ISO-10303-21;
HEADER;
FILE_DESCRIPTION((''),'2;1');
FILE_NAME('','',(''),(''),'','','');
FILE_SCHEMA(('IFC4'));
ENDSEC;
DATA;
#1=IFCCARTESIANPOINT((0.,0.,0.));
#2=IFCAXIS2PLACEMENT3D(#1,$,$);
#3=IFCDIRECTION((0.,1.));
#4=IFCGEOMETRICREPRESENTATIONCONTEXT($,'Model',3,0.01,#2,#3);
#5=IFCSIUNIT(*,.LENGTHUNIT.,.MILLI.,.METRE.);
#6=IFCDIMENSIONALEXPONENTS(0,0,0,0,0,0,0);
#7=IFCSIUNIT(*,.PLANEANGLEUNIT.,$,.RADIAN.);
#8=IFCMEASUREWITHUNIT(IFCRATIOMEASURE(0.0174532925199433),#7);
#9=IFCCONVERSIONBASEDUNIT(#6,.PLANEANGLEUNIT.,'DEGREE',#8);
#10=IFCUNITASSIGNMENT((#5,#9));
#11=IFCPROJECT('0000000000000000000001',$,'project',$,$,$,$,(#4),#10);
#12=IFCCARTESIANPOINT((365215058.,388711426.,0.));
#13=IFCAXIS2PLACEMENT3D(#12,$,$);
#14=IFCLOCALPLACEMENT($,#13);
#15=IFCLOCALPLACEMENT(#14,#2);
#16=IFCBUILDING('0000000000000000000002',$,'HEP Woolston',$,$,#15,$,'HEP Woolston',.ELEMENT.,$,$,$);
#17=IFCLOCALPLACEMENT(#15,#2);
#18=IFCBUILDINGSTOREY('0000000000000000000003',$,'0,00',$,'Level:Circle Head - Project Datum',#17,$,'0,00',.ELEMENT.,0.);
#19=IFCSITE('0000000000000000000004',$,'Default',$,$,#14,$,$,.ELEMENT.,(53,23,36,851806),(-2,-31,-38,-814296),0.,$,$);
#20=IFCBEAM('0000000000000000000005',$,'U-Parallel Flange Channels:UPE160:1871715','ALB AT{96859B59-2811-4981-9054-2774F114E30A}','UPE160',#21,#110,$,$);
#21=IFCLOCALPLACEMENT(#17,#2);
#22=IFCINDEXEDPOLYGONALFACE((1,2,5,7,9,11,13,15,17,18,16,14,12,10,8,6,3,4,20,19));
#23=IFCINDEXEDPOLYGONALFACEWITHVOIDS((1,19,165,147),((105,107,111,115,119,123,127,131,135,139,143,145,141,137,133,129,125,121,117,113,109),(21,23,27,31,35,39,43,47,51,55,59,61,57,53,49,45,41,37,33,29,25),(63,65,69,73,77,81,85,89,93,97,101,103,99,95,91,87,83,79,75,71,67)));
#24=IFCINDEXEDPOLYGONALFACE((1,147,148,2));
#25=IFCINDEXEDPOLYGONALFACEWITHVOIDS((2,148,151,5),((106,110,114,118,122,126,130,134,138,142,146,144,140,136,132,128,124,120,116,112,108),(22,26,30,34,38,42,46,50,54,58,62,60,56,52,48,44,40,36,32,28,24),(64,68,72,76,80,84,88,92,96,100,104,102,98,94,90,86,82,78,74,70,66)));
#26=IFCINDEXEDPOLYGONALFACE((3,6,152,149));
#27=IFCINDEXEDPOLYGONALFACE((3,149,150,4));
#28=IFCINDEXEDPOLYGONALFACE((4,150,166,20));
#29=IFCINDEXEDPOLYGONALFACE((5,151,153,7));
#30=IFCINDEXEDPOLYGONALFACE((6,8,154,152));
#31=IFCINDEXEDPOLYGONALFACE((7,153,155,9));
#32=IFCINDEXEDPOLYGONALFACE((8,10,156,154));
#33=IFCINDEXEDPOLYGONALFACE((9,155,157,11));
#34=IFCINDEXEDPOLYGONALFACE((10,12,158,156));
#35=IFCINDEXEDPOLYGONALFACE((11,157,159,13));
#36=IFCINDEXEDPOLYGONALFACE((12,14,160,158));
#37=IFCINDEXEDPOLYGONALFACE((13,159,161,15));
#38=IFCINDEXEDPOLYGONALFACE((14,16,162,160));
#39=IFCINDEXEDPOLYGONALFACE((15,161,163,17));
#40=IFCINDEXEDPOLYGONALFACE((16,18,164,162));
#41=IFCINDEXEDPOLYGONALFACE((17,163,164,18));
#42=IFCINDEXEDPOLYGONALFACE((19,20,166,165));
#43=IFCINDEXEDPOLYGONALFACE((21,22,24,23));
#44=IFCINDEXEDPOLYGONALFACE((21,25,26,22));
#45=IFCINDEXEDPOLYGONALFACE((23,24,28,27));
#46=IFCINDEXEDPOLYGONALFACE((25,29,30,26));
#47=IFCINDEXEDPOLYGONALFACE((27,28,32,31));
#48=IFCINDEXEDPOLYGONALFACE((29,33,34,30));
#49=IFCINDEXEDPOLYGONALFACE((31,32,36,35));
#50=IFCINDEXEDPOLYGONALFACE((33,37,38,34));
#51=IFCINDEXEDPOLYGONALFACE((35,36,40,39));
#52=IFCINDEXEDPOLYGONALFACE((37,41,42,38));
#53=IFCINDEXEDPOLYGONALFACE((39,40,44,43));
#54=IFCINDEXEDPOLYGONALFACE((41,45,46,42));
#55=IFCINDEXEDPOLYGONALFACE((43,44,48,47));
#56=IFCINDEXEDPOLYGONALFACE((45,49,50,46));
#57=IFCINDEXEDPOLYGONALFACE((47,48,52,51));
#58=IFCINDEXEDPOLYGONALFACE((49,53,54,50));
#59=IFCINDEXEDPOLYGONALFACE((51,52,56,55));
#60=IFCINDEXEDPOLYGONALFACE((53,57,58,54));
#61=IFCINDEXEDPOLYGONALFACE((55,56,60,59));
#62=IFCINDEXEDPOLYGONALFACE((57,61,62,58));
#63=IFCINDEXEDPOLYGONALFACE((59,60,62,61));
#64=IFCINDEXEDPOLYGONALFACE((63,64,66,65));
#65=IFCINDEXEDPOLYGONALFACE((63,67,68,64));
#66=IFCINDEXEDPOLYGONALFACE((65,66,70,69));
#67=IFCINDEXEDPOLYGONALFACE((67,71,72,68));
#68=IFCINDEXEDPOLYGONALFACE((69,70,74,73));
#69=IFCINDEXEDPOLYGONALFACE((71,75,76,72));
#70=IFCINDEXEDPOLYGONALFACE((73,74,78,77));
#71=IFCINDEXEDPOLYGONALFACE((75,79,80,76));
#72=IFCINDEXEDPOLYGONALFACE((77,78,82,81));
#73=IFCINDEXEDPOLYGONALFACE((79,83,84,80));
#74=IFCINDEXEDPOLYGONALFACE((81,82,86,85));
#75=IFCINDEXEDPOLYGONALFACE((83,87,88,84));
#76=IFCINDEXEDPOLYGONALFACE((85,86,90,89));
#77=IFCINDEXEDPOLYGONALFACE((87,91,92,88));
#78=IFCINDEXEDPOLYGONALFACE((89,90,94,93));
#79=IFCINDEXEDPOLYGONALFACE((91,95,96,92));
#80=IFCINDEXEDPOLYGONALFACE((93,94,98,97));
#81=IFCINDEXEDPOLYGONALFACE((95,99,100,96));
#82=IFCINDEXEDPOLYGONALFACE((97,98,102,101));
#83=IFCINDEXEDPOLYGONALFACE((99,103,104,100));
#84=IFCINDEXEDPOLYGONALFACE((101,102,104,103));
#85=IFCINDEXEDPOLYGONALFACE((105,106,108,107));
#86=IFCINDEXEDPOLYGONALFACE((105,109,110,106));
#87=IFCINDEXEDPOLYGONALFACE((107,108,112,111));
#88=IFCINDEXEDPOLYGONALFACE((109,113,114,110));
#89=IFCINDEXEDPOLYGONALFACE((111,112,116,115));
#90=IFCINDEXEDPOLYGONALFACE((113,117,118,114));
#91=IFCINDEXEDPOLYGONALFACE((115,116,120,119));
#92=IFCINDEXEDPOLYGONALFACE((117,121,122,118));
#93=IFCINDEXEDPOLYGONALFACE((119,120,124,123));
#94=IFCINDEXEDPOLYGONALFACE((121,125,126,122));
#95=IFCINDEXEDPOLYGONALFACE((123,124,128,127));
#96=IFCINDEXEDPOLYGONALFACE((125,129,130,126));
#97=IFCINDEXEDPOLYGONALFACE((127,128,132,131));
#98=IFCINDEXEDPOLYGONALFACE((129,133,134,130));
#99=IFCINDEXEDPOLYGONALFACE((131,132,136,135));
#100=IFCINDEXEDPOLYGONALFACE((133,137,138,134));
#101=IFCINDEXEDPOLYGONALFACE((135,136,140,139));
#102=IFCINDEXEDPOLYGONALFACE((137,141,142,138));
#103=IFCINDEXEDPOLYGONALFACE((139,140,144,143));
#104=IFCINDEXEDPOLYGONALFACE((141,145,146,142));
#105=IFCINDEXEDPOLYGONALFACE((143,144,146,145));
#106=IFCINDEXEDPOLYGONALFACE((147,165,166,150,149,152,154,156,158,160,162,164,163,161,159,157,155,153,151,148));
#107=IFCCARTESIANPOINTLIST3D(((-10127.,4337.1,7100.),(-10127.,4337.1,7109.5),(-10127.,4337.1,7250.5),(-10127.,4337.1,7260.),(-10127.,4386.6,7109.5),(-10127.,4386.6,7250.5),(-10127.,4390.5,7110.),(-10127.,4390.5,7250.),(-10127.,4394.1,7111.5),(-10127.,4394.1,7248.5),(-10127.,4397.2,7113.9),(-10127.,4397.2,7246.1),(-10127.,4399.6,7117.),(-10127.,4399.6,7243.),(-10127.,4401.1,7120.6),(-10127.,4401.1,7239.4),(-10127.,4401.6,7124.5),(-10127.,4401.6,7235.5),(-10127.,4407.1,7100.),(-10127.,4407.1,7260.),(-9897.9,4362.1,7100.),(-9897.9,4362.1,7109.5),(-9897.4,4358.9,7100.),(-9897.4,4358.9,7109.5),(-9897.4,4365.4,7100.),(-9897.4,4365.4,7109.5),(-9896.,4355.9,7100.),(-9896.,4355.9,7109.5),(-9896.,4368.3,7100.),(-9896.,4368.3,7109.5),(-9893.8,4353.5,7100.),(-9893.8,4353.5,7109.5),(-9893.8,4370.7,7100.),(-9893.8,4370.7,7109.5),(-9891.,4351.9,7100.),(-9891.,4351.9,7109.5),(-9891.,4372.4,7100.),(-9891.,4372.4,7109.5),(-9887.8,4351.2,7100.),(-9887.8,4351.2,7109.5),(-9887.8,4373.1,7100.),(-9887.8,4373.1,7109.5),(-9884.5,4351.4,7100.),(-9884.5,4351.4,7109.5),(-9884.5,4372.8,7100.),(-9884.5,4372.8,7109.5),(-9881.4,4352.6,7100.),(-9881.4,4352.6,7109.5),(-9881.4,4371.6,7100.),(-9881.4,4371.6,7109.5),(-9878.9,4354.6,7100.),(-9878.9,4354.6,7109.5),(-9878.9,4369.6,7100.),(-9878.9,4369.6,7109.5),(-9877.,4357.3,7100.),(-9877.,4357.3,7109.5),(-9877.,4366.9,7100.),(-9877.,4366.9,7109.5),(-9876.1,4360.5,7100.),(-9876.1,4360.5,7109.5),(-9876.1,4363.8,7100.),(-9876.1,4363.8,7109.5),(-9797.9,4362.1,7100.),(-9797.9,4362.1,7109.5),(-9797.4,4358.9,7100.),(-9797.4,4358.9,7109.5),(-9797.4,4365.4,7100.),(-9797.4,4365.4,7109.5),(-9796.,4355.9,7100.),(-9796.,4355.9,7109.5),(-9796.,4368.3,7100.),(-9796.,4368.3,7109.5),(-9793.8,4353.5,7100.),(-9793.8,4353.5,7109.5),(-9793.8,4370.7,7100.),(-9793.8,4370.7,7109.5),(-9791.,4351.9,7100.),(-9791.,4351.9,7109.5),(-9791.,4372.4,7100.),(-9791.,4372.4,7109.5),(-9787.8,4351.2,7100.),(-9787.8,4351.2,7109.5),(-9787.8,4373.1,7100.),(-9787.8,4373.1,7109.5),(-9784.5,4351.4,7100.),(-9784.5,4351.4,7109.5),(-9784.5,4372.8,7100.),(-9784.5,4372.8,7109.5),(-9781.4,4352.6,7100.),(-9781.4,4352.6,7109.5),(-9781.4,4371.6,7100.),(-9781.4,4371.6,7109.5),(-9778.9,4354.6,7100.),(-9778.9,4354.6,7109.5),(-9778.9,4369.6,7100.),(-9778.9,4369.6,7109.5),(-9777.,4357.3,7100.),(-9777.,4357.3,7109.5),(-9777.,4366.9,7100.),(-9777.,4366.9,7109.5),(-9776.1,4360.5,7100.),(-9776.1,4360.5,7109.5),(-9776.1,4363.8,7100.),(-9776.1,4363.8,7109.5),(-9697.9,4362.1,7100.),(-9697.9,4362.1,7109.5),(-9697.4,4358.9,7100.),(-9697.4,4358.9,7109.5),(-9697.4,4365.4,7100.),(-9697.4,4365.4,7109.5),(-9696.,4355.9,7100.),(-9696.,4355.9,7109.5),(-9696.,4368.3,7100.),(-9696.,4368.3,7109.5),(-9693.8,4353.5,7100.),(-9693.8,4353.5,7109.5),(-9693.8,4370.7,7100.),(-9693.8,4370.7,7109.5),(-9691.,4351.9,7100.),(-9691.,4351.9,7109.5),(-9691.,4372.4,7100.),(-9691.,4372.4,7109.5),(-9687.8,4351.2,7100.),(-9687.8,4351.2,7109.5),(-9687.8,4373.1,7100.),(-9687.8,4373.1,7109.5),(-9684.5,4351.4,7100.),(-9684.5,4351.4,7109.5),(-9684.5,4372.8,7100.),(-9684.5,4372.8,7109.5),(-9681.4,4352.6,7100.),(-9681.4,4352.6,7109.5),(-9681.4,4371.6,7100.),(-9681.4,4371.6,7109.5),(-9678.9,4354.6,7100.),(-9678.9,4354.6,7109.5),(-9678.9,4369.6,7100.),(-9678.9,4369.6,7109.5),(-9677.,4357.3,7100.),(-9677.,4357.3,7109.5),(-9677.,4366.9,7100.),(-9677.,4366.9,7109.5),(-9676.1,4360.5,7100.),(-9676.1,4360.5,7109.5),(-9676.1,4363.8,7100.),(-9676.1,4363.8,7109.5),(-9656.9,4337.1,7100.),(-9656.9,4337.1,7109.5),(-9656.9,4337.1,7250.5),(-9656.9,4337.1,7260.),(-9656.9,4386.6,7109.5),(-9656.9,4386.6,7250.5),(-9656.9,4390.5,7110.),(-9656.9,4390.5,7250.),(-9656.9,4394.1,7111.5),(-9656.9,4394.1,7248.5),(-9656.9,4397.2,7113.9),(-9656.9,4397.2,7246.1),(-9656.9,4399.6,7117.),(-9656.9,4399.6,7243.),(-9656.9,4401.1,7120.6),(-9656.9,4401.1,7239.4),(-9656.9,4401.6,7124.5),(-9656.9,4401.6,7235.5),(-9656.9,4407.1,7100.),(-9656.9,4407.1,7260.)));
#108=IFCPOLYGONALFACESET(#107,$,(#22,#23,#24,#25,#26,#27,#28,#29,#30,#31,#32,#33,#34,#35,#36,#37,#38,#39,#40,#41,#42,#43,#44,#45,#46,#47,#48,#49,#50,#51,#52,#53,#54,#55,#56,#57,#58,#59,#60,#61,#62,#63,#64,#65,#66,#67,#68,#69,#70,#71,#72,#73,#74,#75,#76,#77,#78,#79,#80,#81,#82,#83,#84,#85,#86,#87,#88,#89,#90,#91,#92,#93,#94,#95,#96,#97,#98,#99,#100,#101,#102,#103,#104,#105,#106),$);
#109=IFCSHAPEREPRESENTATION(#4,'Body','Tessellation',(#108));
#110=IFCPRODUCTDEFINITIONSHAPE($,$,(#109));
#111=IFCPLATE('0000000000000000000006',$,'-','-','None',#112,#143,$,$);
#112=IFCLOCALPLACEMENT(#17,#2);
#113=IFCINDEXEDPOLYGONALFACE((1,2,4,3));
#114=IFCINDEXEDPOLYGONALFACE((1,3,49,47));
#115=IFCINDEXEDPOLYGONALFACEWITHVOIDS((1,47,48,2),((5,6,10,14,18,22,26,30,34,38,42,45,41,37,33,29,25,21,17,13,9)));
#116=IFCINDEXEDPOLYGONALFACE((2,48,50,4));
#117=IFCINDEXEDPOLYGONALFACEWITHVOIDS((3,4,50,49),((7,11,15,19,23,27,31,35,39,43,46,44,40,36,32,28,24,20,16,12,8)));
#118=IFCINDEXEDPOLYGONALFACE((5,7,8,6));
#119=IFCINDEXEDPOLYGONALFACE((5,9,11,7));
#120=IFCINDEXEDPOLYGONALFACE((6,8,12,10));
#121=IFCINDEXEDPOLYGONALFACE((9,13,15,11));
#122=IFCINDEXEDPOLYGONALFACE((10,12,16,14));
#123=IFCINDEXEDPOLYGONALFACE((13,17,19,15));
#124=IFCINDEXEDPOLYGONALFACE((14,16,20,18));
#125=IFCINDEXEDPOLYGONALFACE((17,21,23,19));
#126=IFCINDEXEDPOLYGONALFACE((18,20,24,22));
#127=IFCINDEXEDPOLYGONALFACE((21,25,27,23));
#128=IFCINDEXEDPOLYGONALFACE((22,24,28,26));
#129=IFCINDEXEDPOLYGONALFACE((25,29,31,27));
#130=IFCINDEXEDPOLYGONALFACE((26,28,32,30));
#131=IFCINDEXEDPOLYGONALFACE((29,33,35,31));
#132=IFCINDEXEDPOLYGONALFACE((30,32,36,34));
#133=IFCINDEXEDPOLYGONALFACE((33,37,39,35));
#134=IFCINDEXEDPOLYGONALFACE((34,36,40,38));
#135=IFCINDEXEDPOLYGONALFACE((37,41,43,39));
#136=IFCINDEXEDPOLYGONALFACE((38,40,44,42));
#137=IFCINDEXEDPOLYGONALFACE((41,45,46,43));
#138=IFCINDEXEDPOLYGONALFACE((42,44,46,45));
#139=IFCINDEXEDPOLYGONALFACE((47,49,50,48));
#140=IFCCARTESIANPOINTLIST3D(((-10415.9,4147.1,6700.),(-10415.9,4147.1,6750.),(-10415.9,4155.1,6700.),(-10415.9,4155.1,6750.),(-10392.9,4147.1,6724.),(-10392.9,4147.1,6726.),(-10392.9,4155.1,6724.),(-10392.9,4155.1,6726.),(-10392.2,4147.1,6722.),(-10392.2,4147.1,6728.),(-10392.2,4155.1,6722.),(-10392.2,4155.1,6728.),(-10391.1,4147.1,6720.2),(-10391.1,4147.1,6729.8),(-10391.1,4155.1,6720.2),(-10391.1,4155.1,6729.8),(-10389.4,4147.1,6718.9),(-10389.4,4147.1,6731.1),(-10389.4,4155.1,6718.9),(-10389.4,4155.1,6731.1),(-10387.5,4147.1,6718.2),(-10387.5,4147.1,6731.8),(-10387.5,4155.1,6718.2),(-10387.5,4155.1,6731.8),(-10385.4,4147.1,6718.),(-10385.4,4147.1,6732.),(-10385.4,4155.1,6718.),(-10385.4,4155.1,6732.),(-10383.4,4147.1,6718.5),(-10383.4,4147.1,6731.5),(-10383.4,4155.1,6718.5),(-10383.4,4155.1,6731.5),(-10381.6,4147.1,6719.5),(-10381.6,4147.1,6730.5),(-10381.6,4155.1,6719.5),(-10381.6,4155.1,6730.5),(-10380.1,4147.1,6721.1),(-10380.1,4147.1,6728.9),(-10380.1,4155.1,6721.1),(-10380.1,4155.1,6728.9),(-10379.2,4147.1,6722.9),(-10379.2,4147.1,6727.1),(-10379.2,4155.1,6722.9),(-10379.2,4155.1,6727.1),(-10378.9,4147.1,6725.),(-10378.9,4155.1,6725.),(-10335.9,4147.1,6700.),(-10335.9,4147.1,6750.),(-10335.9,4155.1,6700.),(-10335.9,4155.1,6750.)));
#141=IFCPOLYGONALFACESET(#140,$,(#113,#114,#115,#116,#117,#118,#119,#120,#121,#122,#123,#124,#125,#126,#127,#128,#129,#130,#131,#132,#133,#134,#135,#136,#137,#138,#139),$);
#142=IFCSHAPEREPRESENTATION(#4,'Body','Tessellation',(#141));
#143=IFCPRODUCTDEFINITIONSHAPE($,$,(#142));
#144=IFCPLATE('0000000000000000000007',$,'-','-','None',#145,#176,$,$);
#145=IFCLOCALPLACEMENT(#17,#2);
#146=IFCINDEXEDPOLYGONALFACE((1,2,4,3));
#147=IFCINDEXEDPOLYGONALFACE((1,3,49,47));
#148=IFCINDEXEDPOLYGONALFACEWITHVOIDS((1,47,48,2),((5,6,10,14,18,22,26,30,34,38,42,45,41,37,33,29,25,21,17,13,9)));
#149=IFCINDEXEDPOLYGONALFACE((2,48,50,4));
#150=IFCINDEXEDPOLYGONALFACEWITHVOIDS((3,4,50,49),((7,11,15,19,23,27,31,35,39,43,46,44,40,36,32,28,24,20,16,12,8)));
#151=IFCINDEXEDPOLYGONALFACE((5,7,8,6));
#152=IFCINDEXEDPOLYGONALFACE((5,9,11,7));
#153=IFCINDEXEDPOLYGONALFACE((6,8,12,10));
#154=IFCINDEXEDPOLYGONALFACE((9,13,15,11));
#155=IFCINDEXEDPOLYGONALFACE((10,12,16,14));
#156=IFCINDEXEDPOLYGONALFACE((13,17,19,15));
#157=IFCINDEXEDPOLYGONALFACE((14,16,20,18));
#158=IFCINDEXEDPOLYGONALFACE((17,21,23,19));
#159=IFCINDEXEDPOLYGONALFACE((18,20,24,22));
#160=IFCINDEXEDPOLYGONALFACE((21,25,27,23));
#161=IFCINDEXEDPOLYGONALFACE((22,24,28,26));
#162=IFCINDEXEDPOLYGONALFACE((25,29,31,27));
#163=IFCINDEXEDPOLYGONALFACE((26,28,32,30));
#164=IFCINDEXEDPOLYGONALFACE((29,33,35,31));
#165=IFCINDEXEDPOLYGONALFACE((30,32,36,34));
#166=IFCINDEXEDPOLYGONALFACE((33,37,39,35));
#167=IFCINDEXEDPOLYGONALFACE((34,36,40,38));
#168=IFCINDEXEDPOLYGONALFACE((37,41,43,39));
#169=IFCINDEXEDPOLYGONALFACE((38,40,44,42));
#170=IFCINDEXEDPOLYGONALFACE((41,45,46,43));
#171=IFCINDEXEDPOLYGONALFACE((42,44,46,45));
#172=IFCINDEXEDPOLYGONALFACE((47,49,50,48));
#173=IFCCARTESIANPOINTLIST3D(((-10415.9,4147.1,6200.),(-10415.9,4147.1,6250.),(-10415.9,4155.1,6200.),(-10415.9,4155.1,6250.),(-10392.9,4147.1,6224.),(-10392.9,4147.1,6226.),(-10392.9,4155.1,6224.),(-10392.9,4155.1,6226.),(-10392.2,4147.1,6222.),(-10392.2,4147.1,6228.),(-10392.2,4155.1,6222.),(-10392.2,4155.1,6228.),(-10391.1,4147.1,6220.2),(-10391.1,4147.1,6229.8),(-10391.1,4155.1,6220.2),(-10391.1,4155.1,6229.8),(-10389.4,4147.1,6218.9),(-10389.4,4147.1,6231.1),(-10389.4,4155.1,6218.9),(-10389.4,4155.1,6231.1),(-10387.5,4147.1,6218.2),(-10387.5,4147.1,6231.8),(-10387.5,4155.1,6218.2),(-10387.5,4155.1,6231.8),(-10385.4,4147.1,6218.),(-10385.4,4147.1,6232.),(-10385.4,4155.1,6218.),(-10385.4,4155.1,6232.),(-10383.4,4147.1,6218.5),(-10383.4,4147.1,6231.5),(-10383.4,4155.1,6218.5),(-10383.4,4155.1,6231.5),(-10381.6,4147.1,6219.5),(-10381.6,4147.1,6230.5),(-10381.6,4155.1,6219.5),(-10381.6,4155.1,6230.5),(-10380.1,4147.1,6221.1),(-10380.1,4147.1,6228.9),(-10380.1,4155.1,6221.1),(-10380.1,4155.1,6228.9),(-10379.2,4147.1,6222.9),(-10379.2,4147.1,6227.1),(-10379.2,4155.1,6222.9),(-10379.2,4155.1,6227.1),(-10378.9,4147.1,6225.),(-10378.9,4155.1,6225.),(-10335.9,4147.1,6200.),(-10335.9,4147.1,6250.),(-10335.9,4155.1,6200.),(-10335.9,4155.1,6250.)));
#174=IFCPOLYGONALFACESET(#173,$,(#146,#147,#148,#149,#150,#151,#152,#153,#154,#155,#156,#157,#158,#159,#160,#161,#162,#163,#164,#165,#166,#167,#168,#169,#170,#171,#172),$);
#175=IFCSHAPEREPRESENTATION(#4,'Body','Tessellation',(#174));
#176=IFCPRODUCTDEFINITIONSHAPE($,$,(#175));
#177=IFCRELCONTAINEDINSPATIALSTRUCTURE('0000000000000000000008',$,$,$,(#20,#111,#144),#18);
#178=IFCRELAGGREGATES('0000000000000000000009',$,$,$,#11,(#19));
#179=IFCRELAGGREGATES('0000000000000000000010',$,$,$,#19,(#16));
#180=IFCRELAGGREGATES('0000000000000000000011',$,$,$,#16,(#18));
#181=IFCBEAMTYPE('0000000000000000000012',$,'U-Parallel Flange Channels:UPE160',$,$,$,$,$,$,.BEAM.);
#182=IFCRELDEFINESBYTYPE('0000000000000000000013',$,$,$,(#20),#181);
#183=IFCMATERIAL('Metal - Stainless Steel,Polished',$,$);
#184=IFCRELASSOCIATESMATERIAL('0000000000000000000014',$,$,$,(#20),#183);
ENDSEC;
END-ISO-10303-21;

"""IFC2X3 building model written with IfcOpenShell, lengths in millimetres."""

from ifc_helpers import new_model, entity, si_unit, converted_unit, direction, frame, frame_2d, origin, origin_with_axes, origin_2d_with_axis, place, context, project, spatial, polyline, circle, u_section, outline, extrude, clip, halfspace, material, type_object, element, save


model = new_model("IFC2X3")

# Units and contexts
model_context = context("Model", 3, precision=0.01, world=origin(), true_north=direction((0.0, 1.0)))
ifc_project = project(units=[si_unit("LENGTHUNIT", "METRE", prefix="MILLI"), converted_unit("PLANEANGLEUNIT", "DEGREE", entity("IfcRatioMeasure", 0.0174532925199433), si_unit("PLANEANGLEUNIT", "RADIAN"), dimensions=[0, 0, 0, 0, 0, 0, 0])], contexts=[model_context])

# Site, building, storey
site_placement = place(None, frame((365215058.0, 388711426.0, 0.0)))
site = spatial("IfcSite", under=ifc_project, at=site_placement, Name="Default", CompositionType="ELEMENT", RefLatitude=(53, 23, 36, 851806), RefLongitude=(-2, -31, -38, -814296), RefElevation=0.0)
building_placement = place(site_placement, origin())
building = spatial("IfcBuilding", under=site, at=building_placement, Name="HEP Woolston", LongName="HEP Woolston", CompositionType="ELEMENT")
storey_placement = place(building_placement, origin())
storey = spatial("IfcBuildingStorey", under=building, at=storey_placement, Name="0,00", ObjectType="Level:Circle Head - Project Datum", LongName="0,00", CompositionType="ELEMENT", Elevation=0.0)

# Beam, openings
ifc_material = material(Name="Metal - Stainless Steel,Polished")
beam_type = type_object("IfcBeamType", Name="U-Parallel Flange Channels:UPE160", PredefinedType="BEAM")
beam_placement = place(storey_placement, frame((-10127.0, 4407.1, 7180.0), z_axis=(-1.0, 0.0, 0.0), x_axis=(0.0, -1.0, 0.0)))
beam = element("IfcBeam", 1, at=beam_placement, inside=storey, type_object=beam_type, material=ifc_material, Name="U-Parallel Flange Channels:UPE160:1871715", Description="ALB AT{96859B59-2811-4981-9054-2774F114E30A}", ObjectType="UPE160", context=model_context, shape_type="Clipping", body=[
    clip(extrude(u_section(Depth=160.0, FlangeWidth=70.0, WebThickness=5.5, FlangeThickness=9.5, FilletRadius=15.0, EdgeRadius=0.0, FlangeSlope=0.0, at=frame_2d((35.0, 0.0))), origin(), (0.0, 0.0, -1.0), 7737.4), halfspace(frame((4407.1, -7180.0, -470.1), z_axis=(0.0, 0.0, 1.0), x_axis=(1.0, 0.0, 0.0)), True)),
])
opening_1_placement = place(beam_placement, frame((45.0, -80.5, -340.1), z_axis=(0.0, 1.0, 0.0), x_axis=(0.0, 0.0, 1.0)))
element("IfcOpeningElement", 2, at=opening_1_placement, cuts=beam, ObjectType="Opening", context=model_context, shape_type="SweptSolid", body=[
    extrude(circle(Radius=11.0, at=origin_2d_with_axis()), origin(), (0.0, 0.0, 1.0), 10.5),
])
opening_2_placement = place(beam_placement, frame((45.0, -80.5, -340.1), z_axis=(0.0, 1.0, 0.0), x_axis=(0.0, 0.0, 1.0)))
element("IfcOpeningElement", 3, at=opening_2_placement, cuts=beam, ObjectType="Opening", context=model_context, shape_type="SweptSolid", body=[
    extrude(circle(Radius=11.0, at=frame_2d((100.0, 0.0), x_axis=(1.0, 0.0))), origin(), (0.0, 0.0, 1.0), 10.5),
])
opening_3_placement = place(beam_placement, frame((45.0, -80.5, -340.1), z_axis=(0.0, 1.0, 0.0), x_axis=(0.0, 0.0, 1.0)))
element("IfcOpeningElement", 4, at=opening_3_placement, cuts=beam, ObjectType="Opening", context=model_context, shape_type="SweptSolid", body=[
    extrude(circle(Radius=11.0, at=frame_2d((-100.0, 0.0), x_axis=(1.0, 0.0))), origin(), (0.0, 0.0, 1.0), 10.5),
])

# Plates, openings
plate_1_placement = place(storey_placement, frame((-10335.9, 4147.1, 6750.0), z_axis=(0.0, 1.0, 0.0), x_axis=(-1.0, 0.0, 0.0)))
plate_1 = element("IfcPlate", 5, at=plate_1_placement, inside=storey, Name="-", Description="-", ObjectType="None", context=model_context, shape_type="SweptSolid", body=[
    extrude(outline(polyline([(0.0, 0.0), (0.0, -50.0), (80.0, -50.0), (80.0, 0.0), (0.0, 0.0)])), origin_with_axes(), (0.0, 0.0, 1.0), 8.0),
])
opening_4_placement = place(plate_1_placement, frame((50.0, -25.0, 8.5), z_axis=(0.0, 0.0, -1.0), x_axis=(-1.0, 0.0, 0.0)))
element("IfcOpeningElement", 6, at=opening_4_placement, cuts=plate_1, ObjectType="Opening", context=model_context, shape_type="SweptSolid", body=[
    extrude(circle(Radius=7.0, at=origin_2d_with_axis()), origin(), (0.0, 0.0, 1.0), 9.0),
])
plate_2_placement = place(storey_placement, frame((-10335.9, 4147.1, 6250.0), z_axis=(0.0, 1.0, 0.0), x_axis=(-1.0, 0.0, 0.0)))
plate_2 = element("IfcPlate", 7, at=plate_2_placement, inside=storey, Name="-", Description="-", ObjectType="None", context=model_context, shape_type="SweptSolid", body=[
    extrude(outline(polyline([(0.0, 0.0), (0.0, -50.0), (80.0, -50.0), (80.0, 0.0), (0.0, 0.0)])), origin_with_axes(), (0.0, 0.0, 1.0), 8.0),
])
opening_5_placement = place(plate_2_placement, frame((50.0, -25.0, 8.5), z_axis=(0.0, 0.0, -1.0), x_axis=(-1.0, 0.0, 0.0)))
element("IfcOpeningElement", 8, at=opening_5_placement, cuts=plate_2, ObjectType="Opening", context=model_context, shape_type="SweptSolid", body=[
    extrude(circle(Radius=7.0, at=origin_2d_with_axis()), origin(), (0.0, 0.0, 1.0), 9.0),
])

save(model, "model.ifc")
